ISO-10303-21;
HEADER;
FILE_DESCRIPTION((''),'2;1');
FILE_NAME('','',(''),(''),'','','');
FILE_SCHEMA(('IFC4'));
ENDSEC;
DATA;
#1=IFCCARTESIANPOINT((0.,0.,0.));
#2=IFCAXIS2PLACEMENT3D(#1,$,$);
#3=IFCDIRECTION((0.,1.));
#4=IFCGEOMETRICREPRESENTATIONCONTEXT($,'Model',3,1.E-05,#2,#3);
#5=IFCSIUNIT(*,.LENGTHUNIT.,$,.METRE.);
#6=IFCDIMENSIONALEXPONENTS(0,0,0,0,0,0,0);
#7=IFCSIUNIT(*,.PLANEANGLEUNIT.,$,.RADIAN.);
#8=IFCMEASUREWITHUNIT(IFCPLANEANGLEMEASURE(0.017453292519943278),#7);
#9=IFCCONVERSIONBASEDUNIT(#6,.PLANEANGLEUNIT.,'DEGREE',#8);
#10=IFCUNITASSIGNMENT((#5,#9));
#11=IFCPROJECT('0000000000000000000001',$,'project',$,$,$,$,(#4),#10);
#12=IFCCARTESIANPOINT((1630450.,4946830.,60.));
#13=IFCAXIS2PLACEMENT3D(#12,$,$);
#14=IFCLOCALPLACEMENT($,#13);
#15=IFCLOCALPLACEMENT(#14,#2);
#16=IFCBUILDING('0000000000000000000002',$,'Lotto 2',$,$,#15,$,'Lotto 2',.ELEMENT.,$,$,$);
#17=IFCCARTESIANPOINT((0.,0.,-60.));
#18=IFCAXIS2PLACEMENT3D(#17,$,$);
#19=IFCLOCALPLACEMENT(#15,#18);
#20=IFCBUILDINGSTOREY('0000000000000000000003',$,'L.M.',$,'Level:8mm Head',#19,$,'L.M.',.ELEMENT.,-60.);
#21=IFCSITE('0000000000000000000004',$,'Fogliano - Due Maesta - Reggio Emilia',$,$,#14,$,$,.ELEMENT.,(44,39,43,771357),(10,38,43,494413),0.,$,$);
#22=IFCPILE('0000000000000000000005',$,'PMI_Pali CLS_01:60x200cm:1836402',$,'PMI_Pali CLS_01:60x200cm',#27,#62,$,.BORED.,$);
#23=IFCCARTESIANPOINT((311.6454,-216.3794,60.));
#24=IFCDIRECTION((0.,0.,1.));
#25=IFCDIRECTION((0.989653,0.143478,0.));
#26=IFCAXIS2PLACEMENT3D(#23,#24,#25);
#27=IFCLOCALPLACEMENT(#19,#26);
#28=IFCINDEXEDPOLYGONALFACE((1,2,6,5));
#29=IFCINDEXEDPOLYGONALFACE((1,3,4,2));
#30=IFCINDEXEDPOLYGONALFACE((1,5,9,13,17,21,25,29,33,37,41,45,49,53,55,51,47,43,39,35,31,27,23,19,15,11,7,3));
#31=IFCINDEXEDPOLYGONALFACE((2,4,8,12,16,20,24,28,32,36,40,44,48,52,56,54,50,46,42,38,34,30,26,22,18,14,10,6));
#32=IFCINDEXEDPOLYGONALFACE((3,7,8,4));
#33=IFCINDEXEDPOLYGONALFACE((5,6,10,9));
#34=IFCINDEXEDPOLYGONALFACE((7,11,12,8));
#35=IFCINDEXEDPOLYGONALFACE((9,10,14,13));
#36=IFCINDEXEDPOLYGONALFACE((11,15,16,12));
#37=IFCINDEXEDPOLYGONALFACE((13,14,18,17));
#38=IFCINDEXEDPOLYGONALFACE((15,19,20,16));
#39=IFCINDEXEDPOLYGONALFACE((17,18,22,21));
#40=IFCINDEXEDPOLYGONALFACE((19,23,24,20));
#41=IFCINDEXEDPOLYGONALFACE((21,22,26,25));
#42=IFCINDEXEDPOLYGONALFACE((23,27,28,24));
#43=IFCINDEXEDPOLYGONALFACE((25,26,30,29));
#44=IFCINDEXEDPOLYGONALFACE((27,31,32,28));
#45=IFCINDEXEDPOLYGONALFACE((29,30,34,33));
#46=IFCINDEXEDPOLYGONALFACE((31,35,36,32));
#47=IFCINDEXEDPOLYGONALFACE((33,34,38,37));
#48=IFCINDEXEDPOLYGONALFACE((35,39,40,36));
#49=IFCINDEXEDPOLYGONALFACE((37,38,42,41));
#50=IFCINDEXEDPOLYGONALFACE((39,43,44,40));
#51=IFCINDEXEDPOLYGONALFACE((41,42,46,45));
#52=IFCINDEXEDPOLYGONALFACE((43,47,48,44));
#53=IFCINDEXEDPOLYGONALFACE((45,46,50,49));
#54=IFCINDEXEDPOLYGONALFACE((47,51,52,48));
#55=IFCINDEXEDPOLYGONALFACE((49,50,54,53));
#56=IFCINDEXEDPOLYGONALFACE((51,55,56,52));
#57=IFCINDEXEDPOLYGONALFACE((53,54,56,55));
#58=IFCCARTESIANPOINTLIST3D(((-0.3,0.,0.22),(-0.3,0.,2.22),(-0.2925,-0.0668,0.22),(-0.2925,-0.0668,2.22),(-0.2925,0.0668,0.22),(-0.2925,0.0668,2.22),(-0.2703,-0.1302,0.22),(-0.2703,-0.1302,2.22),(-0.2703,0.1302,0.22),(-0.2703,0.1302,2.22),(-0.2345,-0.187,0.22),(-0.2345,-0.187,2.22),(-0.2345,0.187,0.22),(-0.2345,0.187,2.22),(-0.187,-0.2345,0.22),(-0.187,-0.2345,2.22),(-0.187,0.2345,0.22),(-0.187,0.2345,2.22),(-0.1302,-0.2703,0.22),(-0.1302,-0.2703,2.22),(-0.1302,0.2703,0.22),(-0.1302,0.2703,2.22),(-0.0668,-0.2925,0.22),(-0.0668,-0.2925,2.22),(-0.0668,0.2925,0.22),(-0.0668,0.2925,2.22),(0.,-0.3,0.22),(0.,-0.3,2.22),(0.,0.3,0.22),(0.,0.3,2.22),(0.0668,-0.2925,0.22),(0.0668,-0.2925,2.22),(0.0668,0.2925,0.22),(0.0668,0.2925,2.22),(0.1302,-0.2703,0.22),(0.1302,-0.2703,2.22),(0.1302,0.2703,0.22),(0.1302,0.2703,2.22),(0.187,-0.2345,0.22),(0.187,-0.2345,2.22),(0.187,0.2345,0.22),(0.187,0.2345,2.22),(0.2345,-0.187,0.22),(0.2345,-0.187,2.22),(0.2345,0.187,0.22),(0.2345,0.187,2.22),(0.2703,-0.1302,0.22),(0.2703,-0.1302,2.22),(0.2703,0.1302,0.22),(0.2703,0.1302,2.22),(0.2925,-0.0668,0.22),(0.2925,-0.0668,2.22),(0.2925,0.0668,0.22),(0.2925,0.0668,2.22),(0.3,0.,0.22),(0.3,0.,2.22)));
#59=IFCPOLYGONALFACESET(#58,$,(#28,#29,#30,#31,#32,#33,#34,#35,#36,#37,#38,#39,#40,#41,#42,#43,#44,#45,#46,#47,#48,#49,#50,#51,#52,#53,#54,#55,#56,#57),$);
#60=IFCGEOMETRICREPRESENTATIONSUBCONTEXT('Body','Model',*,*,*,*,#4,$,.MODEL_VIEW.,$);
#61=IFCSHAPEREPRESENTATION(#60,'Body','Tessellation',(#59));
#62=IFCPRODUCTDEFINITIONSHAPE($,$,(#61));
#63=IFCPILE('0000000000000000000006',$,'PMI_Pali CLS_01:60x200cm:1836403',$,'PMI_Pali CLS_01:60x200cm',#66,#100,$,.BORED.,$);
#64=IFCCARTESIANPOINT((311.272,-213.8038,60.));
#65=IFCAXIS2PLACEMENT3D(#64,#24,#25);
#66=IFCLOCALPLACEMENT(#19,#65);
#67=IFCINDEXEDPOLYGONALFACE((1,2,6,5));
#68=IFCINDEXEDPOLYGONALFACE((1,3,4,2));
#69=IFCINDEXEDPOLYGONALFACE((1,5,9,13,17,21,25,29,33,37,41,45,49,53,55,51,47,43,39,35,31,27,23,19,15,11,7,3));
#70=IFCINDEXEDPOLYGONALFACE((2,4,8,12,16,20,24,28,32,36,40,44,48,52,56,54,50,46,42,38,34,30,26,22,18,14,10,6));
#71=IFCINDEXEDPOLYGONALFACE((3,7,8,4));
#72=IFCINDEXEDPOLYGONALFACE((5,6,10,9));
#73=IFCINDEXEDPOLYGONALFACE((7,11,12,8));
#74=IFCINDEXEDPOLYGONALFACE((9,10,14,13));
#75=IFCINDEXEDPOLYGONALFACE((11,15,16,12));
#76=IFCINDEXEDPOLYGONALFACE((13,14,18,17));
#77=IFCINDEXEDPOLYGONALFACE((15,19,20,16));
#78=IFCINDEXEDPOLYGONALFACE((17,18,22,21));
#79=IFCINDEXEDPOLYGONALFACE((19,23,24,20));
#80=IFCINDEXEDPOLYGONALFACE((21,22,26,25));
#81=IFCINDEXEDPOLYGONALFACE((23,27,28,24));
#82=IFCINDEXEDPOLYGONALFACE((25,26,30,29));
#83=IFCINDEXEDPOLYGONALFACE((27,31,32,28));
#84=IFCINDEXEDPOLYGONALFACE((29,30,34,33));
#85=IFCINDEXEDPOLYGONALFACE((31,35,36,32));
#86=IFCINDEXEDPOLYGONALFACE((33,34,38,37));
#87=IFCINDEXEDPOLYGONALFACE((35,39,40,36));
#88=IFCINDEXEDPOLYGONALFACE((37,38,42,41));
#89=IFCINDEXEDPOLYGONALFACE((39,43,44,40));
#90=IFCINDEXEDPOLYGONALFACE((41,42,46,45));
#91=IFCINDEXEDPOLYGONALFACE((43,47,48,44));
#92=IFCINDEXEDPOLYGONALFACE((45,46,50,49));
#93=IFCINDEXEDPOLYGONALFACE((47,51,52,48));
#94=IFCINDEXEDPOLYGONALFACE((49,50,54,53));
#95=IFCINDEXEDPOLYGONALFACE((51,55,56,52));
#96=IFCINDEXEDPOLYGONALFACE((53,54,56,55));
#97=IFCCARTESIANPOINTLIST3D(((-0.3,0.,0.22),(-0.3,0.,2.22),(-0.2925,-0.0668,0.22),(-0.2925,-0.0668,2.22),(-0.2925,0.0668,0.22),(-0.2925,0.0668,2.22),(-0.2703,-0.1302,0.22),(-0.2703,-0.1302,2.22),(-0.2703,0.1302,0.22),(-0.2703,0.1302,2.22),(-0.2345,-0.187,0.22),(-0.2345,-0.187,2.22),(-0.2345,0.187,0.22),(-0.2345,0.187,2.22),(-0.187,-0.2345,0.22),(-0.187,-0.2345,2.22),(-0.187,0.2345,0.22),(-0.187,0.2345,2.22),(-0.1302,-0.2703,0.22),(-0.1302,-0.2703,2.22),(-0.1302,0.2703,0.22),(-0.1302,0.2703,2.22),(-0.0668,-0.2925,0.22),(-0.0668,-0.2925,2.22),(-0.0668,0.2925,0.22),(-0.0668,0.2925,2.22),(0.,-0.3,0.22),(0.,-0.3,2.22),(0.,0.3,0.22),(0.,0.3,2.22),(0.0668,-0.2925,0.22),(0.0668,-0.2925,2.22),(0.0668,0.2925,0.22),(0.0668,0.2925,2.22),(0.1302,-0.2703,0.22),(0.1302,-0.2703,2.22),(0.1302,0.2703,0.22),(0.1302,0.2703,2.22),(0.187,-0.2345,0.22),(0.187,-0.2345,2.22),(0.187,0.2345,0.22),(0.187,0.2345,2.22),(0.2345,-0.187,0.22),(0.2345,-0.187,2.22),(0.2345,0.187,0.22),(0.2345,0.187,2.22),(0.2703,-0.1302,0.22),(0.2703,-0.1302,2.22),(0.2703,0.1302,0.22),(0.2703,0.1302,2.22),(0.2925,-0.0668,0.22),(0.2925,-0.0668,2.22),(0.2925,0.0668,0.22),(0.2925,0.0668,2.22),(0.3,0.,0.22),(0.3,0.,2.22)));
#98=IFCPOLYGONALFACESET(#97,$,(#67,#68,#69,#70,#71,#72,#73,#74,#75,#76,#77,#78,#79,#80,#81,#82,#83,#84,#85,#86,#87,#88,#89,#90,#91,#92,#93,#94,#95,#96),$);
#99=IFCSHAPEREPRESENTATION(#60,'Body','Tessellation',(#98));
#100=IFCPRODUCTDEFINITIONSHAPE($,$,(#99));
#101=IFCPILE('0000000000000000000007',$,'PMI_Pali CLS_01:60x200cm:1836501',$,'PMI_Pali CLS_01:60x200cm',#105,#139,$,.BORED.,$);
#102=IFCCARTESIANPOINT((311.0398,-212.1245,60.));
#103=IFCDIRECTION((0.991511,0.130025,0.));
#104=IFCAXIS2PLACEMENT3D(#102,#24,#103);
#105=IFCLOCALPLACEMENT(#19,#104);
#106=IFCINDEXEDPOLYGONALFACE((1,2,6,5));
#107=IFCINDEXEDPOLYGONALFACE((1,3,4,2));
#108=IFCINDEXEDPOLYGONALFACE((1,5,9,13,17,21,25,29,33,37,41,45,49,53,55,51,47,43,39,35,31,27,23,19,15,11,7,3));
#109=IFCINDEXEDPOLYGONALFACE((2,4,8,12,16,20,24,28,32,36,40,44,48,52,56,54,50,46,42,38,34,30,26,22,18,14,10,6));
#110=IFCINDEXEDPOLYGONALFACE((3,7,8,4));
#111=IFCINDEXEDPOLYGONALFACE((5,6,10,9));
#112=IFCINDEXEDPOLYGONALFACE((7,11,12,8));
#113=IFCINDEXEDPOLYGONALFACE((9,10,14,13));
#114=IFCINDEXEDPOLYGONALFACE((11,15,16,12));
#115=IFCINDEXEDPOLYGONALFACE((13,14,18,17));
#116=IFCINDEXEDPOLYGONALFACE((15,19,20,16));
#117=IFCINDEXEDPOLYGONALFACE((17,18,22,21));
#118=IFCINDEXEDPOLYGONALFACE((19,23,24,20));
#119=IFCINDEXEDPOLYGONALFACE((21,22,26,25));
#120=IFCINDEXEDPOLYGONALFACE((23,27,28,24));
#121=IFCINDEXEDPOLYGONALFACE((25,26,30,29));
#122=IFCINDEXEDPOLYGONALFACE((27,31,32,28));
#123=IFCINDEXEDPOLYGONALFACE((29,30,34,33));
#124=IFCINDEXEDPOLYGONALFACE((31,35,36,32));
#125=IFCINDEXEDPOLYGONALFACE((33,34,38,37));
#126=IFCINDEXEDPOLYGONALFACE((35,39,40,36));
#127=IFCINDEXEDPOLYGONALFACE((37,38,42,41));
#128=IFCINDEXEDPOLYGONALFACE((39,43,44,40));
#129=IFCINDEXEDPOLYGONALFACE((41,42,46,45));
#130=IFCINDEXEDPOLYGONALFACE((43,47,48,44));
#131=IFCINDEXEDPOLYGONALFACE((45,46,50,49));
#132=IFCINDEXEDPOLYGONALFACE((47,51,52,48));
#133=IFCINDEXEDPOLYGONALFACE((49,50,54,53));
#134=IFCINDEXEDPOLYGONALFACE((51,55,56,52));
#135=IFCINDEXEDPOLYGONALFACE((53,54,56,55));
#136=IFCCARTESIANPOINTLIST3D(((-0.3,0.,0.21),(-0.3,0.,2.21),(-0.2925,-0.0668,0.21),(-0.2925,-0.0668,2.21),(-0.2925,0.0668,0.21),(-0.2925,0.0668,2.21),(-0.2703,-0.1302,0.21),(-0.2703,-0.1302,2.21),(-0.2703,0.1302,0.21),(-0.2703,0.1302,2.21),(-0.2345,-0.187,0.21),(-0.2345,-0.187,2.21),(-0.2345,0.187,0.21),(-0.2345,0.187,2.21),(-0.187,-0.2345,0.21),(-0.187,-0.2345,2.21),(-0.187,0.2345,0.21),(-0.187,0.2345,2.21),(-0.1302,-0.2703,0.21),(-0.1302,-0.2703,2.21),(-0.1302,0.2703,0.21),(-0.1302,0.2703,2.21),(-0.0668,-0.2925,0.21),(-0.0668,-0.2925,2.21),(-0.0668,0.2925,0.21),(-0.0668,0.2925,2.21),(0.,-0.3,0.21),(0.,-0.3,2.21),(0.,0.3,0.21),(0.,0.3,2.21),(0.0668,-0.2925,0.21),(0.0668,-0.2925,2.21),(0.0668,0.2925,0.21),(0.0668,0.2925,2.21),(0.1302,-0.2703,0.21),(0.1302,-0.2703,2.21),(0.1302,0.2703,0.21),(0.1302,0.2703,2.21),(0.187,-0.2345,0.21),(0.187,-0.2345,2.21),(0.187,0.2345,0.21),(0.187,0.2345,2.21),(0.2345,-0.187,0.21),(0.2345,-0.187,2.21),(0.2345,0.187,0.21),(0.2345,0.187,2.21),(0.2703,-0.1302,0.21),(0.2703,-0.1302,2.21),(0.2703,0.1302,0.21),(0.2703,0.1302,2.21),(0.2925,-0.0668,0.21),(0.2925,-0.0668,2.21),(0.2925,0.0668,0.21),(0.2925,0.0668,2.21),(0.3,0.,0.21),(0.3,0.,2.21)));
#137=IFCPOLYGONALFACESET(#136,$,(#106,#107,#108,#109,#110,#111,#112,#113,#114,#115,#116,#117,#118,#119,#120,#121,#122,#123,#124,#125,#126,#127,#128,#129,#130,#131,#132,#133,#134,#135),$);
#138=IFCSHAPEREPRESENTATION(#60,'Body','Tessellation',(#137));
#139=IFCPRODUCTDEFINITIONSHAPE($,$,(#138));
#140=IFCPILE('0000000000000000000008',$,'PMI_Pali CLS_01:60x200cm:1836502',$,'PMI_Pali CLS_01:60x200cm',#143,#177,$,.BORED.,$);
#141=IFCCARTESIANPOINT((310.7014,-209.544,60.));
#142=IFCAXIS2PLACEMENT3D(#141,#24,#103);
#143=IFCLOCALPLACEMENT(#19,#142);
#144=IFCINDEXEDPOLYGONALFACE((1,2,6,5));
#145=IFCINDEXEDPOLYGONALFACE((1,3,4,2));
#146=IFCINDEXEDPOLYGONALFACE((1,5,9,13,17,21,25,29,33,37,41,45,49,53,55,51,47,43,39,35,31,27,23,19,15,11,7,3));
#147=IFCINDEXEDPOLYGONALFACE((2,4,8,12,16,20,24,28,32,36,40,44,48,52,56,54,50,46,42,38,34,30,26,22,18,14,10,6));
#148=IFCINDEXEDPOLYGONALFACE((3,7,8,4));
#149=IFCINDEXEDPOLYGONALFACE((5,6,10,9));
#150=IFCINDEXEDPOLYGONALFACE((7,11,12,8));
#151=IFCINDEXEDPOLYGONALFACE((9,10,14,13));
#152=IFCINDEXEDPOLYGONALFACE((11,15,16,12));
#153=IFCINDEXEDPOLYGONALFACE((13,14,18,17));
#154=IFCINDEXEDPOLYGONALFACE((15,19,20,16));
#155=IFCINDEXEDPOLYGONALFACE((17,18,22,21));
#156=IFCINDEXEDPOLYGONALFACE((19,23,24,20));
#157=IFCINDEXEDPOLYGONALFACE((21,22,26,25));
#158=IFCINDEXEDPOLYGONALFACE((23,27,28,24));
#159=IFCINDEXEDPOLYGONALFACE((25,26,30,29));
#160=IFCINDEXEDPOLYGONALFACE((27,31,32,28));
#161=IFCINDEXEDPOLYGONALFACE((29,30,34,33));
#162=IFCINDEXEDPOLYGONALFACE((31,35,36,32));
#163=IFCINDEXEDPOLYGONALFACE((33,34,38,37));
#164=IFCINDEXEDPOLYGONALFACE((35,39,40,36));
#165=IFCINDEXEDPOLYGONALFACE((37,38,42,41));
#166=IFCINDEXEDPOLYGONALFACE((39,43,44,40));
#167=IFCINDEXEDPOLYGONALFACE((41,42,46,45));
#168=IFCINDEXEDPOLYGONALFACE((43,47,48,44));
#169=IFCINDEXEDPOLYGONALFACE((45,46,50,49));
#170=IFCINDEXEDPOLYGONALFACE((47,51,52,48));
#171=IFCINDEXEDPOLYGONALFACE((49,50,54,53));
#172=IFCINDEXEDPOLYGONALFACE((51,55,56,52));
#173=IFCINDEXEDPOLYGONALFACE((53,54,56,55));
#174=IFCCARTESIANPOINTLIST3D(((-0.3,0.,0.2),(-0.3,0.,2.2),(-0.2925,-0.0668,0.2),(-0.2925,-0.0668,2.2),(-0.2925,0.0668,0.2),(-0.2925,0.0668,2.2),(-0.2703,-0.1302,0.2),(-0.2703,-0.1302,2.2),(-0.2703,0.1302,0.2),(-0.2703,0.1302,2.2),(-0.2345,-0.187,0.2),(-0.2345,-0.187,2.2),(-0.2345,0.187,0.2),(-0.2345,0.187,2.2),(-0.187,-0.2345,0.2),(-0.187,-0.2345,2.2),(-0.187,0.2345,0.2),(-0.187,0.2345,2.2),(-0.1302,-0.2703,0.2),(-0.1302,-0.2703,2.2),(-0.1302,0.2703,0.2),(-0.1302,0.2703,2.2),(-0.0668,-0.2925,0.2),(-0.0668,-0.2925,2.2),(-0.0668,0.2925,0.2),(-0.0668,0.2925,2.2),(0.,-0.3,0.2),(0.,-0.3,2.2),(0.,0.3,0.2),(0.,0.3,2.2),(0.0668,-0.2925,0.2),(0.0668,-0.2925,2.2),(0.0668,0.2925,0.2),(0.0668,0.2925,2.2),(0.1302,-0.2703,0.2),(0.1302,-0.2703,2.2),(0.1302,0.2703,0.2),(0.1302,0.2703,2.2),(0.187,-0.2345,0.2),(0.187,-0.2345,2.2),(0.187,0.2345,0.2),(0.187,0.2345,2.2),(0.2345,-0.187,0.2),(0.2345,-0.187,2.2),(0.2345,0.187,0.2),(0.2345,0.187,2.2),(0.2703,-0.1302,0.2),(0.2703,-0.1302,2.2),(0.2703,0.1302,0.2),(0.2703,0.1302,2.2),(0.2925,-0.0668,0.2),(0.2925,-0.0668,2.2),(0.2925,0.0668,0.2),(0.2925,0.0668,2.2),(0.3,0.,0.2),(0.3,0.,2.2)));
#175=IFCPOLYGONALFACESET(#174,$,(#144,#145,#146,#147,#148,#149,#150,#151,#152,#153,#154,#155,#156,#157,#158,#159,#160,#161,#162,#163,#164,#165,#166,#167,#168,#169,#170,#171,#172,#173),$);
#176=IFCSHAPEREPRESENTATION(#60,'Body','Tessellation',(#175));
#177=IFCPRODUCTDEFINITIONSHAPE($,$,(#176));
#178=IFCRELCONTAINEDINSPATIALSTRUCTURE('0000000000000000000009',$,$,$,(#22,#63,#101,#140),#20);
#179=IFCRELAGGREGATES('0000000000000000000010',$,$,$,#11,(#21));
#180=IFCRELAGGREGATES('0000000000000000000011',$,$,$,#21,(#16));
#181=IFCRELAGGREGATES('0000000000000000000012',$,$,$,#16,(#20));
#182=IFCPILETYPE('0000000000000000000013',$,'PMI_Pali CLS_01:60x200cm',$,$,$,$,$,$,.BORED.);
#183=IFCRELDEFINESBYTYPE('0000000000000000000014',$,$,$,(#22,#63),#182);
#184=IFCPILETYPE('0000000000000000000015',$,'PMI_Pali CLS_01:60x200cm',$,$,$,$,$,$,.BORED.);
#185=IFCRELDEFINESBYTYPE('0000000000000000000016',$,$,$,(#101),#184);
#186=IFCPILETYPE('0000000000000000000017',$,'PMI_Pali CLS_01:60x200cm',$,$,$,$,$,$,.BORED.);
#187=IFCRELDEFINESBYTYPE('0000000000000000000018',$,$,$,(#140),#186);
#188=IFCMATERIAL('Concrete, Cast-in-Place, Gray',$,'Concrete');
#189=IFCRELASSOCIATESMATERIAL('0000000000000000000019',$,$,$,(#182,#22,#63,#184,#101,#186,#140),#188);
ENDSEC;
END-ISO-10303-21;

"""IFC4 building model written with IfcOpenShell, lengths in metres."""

from ifc_helpers import new_model, entity, si_unit, converted_unit, direction, frame, origin, place, context, subcontext, project, spatial, arc, indexed_curve, outline, extrude, source, transform, mapped, material, type_object, type_shapes, element, save


model = new_model("IFC4")

# Units and contexts
model_context = context("Model", 3, precision=1e-05, world=origin(), true_north=direction((0.0, 1.0)))
body_context = subcontext(model_context, "Body", "Model", "MODEL_VIEW")
ifc_project = project(units=[si_unit("LENGTHUNIT", "METRE"), converted_unit("PLANEANGLEUNIT", "DEGREE", entity("IfcPlaneAngleMeasure", 0.017453292519943278), si_unit("PLANEANGLEUNIT", "RADIAN"), dimensions=[0, 0, 0, 0, 0, 0, 0])], contexts=[model_context])

# Site, building, storey
site_placement = place(None, frame((1630450.0, 4946830.0, 60.0)))
site = spatial("IfcSite", under=ifc_project, at=site_placement, Name="Fogliano - Due Maesta - Reggio Emilia", CompositionType="ELEMENT", RefLatitude=(44, 39, 43, 771357), RefLongitude=(10, 38, 43, 494413), RefElevation=0.0)
building_placement = place(site_placement, origin())
building = spatial("IfcBuilding", under=site, at=building_placement, Name="Lotto 2", LongName="Lotto 2", CompositionType="ELEMENT")
storey_placement = place(building_placement, frame((0.0, 0.0, -60.0)))
storey = spatial("IfcBuildingStorey", under=building, at=storey_placement, Name="L.M.", ObjectType="Level:8mm Head", LongName="L.M.", CompositionType="ELEMENT", Elevation=-60.0)

# Piles
ifc_material_1 = material(Name="Concrete, Cast-in-Place, Gray", Category="Concrete")
pile_type_1 = type_object("IfcPileType", Name="PMI_Pali CLS_01:60x200cm", PredefinedType="BORED", material=ifc_material_1)
shared_shape_1 = source(origin(), body_context, "Body", "SweptSolid", [
    extrude(outline(indexed_curve([(-0.3, 0.0), (0.0, -0.3), (0.3, 0.0), (0.0, 0.3)], segments=[arc(1, 2, 3), arc(3, 4, 1)], self_intersect=False)), frame((0.0, 0.0, 0.22)), (0.0, 0.0, 1.0), 2.0),
])
type_shapes(pile_type_1, [shared_shape_1])
for number, where, z_axis, x_axis, name in (
    (1, (311.6454, -216.3794, 60.0), (0.0, 0.0, 1.0), (0.989653, 0.143478, 0.0), "PMI_Pali CLS_01:60x200cm:1836402"),
    (2, (311.272, -213.8038, 60.0), (0.0, 0.0, 1.0), (0.989653, 0.143478, 0.0), "PMI_Pali CLS_01:60x200cm:1836403"),
):
    element("IfcPile", number, at=place(storey_placement, frame(where, z_axis=z_axis, x_axis=x_axis)), inside=storey, type_object=pile_type_1, material=ifc_material_1, Name=name, ObjectType="PMI_Pali CLS_01:60x200cm", PredefinedType="BORED", context=body_context, shape_type="MappedRepresentation", body=[
        mapped(shared_shape_1, transform((0.0, 0.0, 0.0), scale=1.0)),
    ])
pile_type_2 = type_object("IfcPileType", Name="PMI_Pali CLS_01:60x200cm", PredefinedType="BORED", material=ifc_material_1)
shared_shape_2 = source(origin(), body_context, "Body", "SweptSolid", [
    extrude(outline(indexed_curve([(-0.3, 0.0), (0.0, -0.3), (0.3, 0.0), (0.0, 0.3)], segments=[arc(1, 2, 3), arc(3, 4, 1)], self_intersect=False)), frame((0.0, 0.0, 0.21)), (0.0, 0.0, 1.0), 2.0),
])
type_shapes(pile_type_2, [shared_shape_2])
pile_1_placement = place(storey_placement, frame((311.0398, -212.1245, 60.0), z_axis=(0.0, 0.0, 1.0), x_axis=(0.991511, 0.130025, 0.0)))
element("IfcPile", 3, at=pile_1_placement, inside=storey, type_object=pile_type_2, material=ifc_material_1, Name="PMI_Pali CLS_01:60x200cm:1836501", ObjectType="PMI_Pali CLS_01:60x200cm", PredefinedType="BORED", context=body_context, shape_type="MappedRepresentation", body=[
    mapped(shared_shape_2, transform((0.0, 0.0, 0.0), scale=1.0)),
])
pile_type_3 = type_object("IfcPileType", Name="PMI_Pali CLS_01:60x200cm", PredefinedType="BORED", material=ifc_material_1)
shared_shape_3 = source(origin(), body_context, "Body", "SweptSolid", [
    extrude(outline(indexed_curve([(-0.3, 0.0), (0.0, -0.3), (0.3, 0.0), (0.0, 0.3)], segments=[arc(1, 2, 3), arc(3, 4, 1)], self_intersect=False)), frame((0.0, 0.0, 0.2)), (0.0, 0.0, 1.0), 2.0),
])
type_shapes(pile_type_3, [shared_shape_3])
pile_2_placement = place(storey_placement, frame((310.7014, -209.544, 60.0), z_axis=(0.0, 0.0, 1.0), x_axis=(0.991511, 0.130025, 0.0)))
element("IfcPile", 4, at=pile_2_placement, inside=storey, type_object=pile_type_3, material=ifc_material_1, Name="PMI_Pali CLS_01:60x200cm:1836502", ObjectType="PMI_Pali CLS_01:60x200cm", PredefinedType="BORED", context=body_context, shape_type="MappedRepresentation", body=[
    mapped(shared_shape_3, transform((0.0, 0.0, 0.0), scale=1.0)),
])

save(model, "model.ifc")
